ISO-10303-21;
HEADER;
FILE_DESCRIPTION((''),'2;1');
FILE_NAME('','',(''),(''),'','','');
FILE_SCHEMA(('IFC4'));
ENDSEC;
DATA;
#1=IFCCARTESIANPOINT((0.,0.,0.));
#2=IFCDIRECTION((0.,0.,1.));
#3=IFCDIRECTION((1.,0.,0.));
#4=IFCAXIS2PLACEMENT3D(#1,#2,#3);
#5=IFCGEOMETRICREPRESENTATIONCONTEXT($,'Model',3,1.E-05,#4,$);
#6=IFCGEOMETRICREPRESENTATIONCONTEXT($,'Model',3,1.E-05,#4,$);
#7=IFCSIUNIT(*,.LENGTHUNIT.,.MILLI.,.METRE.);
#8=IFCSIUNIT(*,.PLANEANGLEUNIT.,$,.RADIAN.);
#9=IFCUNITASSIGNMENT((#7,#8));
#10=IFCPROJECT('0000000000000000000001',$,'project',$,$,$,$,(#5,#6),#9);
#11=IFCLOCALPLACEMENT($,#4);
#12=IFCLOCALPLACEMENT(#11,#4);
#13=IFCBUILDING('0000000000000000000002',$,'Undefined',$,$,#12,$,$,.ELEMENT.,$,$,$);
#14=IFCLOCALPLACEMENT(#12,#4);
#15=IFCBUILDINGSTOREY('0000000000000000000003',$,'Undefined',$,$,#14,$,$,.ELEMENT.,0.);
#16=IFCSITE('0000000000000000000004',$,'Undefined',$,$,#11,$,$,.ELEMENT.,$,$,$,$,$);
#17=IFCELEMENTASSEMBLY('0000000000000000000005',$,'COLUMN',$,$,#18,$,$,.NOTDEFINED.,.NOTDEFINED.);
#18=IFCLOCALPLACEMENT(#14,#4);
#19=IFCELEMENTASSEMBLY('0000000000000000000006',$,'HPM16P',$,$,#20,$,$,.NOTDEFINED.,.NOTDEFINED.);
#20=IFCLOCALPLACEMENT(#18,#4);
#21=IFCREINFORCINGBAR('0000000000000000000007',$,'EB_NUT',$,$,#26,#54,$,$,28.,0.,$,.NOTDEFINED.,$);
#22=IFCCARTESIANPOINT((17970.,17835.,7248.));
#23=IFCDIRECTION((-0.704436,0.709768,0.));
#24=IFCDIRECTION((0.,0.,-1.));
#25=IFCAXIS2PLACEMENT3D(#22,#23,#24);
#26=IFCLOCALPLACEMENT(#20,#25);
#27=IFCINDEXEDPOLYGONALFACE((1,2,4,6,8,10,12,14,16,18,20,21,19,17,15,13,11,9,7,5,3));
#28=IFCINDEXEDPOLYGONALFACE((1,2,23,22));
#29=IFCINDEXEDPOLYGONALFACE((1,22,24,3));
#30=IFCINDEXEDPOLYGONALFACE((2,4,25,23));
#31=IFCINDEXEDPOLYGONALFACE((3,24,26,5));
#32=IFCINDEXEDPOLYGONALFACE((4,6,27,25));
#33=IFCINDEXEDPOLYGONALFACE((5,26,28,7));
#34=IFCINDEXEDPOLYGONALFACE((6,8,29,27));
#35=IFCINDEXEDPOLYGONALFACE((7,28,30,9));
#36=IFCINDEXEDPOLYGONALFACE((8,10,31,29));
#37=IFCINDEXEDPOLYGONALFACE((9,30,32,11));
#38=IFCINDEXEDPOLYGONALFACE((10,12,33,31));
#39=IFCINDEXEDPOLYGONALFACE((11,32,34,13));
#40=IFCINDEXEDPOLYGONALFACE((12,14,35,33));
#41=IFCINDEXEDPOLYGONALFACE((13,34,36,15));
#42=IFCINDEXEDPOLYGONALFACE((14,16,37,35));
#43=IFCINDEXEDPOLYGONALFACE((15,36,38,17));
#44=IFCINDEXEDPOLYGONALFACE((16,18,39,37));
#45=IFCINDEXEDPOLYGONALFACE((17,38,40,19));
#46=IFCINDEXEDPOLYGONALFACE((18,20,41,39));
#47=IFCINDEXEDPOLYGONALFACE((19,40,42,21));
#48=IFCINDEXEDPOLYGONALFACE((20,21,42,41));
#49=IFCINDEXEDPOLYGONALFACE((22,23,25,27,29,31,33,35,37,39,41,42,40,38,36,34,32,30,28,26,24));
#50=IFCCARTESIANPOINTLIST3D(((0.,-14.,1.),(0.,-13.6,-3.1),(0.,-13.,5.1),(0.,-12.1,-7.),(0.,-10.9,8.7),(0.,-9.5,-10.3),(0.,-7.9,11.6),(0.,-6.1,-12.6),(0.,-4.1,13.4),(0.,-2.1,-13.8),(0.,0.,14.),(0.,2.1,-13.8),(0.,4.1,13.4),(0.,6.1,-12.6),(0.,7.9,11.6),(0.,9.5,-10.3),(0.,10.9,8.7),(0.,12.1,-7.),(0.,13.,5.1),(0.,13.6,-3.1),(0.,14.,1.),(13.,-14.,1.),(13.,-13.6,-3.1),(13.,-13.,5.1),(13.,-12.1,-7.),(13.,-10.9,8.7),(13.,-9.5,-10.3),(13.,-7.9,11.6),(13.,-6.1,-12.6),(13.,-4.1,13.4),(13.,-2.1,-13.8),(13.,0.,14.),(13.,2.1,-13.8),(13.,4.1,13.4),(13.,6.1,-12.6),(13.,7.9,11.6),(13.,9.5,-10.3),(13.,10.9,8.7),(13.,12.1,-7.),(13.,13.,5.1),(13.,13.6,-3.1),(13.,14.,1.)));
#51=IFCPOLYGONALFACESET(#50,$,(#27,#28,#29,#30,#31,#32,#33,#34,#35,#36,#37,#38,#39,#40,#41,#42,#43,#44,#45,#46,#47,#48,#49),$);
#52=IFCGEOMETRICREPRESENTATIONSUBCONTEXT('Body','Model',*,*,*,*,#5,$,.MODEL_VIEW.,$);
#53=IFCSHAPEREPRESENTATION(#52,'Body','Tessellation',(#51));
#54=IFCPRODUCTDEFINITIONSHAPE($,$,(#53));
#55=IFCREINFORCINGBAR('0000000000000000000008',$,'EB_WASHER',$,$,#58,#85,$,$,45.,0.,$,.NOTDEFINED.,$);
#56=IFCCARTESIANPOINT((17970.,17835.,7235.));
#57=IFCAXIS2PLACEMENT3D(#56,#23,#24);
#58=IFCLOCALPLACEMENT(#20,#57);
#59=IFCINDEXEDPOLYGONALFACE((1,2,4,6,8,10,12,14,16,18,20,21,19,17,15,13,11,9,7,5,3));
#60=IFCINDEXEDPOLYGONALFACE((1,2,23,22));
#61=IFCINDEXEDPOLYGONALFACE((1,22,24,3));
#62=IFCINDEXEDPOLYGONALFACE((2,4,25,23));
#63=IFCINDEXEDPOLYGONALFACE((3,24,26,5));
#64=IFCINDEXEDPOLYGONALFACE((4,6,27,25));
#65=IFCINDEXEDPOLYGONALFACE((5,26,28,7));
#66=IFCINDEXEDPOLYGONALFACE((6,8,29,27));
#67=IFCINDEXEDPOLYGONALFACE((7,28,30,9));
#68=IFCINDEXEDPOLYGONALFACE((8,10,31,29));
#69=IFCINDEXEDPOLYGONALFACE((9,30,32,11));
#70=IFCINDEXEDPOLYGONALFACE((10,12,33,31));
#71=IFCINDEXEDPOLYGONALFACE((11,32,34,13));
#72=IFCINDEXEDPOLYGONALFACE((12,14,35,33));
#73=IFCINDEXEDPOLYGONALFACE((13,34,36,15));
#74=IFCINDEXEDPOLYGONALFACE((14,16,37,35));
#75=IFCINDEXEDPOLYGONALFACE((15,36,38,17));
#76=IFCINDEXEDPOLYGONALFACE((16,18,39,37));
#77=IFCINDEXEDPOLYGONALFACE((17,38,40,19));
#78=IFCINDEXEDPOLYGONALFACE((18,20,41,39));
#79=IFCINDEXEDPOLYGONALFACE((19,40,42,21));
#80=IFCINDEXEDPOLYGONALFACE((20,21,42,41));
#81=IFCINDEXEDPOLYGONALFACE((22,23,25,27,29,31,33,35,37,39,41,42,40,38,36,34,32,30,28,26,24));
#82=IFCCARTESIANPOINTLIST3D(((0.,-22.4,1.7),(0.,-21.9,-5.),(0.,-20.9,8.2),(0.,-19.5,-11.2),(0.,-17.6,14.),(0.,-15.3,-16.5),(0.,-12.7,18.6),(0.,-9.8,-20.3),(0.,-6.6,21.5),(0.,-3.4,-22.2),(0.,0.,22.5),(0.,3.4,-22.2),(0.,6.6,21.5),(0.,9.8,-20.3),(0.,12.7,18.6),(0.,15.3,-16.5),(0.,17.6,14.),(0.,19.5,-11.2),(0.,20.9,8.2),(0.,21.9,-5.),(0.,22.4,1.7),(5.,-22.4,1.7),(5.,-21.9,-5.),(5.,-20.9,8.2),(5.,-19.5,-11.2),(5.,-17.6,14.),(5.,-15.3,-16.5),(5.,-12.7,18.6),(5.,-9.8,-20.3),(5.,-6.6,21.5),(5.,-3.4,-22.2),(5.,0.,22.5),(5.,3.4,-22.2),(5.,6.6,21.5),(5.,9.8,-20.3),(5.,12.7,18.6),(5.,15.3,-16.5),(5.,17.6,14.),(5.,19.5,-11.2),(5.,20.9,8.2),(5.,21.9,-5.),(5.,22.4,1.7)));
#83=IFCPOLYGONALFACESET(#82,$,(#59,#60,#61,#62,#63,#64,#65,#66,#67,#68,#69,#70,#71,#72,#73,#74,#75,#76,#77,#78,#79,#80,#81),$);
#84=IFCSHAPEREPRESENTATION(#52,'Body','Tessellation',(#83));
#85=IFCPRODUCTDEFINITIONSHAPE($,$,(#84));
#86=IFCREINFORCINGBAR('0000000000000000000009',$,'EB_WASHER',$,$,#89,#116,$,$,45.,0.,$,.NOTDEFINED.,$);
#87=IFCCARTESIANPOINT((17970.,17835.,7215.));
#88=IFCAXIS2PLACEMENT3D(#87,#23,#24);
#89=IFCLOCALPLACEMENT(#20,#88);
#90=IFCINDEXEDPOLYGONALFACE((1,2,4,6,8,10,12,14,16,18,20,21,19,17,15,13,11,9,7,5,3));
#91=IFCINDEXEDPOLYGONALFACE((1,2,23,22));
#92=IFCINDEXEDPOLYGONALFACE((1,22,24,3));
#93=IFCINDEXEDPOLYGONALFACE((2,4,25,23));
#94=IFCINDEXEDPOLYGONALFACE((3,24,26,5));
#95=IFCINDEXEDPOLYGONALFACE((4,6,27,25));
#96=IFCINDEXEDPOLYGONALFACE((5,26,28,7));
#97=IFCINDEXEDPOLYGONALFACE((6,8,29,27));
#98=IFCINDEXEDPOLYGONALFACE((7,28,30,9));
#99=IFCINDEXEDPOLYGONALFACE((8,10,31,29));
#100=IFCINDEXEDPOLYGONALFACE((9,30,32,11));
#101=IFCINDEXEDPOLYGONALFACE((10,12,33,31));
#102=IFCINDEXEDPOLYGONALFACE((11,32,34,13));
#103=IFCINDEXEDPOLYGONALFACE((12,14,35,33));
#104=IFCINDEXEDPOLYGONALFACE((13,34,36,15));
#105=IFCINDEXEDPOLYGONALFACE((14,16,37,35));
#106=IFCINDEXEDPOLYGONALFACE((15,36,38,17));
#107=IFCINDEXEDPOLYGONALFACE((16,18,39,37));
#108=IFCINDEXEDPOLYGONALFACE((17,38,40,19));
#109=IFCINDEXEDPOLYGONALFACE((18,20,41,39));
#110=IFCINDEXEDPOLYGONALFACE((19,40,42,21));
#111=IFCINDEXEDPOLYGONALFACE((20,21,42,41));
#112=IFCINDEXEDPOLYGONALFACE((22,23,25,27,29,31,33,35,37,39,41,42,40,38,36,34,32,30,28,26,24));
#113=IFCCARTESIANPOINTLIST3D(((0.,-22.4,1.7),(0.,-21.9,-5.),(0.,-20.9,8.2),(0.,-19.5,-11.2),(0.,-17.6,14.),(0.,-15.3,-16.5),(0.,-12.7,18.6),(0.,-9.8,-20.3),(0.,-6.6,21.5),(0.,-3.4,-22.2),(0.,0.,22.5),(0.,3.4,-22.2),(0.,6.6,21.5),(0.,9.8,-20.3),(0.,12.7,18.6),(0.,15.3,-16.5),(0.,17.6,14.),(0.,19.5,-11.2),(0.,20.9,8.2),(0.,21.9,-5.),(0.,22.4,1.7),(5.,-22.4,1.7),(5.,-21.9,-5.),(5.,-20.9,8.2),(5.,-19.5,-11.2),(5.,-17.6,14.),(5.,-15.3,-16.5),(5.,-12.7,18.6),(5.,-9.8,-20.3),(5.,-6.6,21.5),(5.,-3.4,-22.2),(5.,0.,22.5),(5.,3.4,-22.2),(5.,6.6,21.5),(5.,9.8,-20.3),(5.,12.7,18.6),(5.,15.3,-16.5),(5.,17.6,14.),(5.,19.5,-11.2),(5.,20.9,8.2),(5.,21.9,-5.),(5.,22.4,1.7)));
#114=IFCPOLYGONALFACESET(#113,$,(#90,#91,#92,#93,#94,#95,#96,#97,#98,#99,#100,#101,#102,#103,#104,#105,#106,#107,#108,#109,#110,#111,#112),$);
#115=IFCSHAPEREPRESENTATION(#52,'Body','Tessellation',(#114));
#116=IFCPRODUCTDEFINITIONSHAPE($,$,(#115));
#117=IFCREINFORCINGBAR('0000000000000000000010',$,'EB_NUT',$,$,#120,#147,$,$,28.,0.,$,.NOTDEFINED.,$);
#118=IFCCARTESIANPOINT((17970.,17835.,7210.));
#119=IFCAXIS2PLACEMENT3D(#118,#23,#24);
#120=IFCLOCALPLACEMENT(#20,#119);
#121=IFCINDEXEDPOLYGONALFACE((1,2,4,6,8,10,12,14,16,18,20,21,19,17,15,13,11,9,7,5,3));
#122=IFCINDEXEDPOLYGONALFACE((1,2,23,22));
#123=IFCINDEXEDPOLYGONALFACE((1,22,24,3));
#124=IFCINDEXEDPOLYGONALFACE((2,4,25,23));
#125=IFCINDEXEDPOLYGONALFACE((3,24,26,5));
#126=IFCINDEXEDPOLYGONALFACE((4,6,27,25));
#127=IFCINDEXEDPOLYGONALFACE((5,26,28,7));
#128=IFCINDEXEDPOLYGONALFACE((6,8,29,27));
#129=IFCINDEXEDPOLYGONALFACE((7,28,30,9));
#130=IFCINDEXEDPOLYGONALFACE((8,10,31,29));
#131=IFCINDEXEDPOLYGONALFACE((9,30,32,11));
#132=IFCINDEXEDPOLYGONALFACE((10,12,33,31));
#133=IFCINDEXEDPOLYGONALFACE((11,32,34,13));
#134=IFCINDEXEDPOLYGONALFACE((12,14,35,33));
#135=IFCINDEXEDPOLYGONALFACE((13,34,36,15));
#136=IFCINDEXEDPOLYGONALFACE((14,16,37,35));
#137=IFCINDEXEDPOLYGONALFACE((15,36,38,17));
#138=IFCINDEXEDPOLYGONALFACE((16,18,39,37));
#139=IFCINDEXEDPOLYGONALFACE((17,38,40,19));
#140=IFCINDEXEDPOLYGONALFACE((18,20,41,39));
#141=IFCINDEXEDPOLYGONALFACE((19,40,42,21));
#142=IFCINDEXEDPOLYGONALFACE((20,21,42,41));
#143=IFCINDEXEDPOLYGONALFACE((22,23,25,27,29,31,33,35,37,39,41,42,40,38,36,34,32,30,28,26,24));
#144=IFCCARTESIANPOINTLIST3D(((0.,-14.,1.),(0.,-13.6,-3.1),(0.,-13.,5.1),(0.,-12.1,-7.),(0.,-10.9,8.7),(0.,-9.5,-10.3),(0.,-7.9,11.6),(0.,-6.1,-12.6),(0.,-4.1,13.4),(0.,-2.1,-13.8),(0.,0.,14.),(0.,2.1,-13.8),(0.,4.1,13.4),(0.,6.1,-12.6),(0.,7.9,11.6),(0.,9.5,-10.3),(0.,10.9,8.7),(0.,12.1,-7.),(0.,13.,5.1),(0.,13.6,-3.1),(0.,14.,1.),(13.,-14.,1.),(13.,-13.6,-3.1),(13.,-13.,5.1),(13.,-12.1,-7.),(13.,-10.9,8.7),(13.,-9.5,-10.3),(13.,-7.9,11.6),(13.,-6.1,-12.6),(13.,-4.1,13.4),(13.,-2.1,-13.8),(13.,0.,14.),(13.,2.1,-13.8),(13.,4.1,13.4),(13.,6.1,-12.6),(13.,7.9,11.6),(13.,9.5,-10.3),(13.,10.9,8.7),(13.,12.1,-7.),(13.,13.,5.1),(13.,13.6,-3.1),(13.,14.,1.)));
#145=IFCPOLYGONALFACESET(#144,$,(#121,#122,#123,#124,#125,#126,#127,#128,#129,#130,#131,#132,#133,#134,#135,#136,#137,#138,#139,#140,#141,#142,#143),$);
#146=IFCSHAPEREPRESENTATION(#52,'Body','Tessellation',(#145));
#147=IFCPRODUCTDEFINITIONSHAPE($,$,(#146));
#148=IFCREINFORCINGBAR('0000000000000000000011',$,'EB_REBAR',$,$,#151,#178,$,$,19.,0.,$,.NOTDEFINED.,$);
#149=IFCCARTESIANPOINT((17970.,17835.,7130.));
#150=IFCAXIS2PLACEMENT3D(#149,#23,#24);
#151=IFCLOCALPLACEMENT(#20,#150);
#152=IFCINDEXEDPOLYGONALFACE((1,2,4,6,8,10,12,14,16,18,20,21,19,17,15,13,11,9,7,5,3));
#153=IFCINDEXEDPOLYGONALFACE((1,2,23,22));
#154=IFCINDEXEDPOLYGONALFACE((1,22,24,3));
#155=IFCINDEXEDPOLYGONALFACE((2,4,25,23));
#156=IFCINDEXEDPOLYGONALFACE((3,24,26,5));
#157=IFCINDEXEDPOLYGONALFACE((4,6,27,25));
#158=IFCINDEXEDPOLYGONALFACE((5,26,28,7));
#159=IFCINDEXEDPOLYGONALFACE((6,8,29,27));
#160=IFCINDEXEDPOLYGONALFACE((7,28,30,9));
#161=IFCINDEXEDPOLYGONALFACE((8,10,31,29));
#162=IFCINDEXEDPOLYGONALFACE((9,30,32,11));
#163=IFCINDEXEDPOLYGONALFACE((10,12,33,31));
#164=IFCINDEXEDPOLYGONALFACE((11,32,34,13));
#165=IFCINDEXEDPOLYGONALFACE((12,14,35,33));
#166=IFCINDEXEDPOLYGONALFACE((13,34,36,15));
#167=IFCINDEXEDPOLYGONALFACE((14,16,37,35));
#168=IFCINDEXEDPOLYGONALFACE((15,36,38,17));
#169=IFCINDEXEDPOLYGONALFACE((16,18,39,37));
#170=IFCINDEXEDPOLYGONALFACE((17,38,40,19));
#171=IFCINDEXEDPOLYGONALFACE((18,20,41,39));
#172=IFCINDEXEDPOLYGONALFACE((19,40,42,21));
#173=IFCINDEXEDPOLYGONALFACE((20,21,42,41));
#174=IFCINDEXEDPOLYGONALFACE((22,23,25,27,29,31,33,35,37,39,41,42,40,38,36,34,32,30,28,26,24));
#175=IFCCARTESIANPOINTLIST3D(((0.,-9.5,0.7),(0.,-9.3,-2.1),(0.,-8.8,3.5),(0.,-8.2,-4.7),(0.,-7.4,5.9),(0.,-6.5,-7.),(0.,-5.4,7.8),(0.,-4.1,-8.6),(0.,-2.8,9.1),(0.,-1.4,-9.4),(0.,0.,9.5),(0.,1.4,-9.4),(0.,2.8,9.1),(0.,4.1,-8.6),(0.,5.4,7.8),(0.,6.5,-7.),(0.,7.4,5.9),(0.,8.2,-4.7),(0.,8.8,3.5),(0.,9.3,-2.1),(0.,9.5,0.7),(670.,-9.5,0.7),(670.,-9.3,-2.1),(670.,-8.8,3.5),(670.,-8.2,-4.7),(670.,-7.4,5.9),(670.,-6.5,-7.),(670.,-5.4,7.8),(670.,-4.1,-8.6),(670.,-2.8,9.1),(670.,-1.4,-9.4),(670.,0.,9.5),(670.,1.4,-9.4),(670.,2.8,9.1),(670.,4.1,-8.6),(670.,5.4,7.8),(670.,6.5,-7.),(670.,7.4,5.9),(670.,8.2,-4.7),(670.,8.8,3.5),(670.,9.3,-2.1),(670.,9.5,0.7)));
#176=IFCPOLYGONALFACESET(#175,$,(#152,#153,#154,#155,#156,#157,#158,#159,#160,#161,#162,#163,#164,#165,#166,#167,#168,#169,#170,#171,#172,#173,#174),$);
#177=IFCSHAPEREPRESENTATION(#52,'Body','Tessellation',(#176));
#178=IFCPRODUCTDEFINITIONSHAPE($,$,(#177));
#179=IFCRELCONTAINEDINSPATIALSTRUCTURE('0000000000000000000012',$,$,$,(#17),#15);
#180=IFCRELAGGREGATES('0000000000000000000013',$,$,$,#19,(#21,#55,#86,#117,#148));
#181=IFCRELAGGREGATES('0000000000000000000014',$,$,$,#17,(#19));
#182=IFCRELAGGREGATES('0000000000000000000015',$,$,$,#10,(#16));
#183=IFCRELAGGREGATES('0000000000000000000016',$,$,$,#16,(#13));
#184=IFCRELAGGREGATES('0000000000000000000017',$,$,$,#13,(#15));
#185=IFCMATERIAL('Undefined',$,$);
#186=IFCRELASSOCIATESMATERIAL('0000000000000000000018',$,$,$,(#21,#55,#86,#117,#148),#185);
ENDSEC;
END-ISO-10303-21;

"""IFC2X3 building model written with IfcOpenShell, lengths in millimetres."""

from ifc_helpers import new_model, entity, si_unit, frame, origin_with_axes, place, context, subcontext, project, spatial, source, transform, mapped, material, element, aggregate, save


model = new_model("IFC2X3")

# Units and contexts
model_context_1 = context("Model", 3, precision=1e-05, world=origin_with_axes())
model_context_2 = context("Model", 3, precision=1e-05, world=origin_with_axes())
body_context = subcontext(model_context_1, "Body", "Model", "MODEL_VIEW")
ifc_project = project(units=[si_unit("LENGTHUNIT", "METRE", prefix="MILLI"), si_unit("PLANEANGLEUNIT", "RADIAN")], contexts=[model_context_1, model_context_2])

# Site, building, storey
site_placement = place(None, origin_with_axes())
site = spatial("IfcSite", under=ifc_project, at=site_placement, Name="Undefined", CompositionType="ELEMENT")
building_placement = place(site_placement, origin_with_axes())
building = spatial("IfcBuilding", under=site, at=building_placement, Name="Undefined", CompositionType="ELEMENT")
storey_placement = place(building_placement, origin_with_axes())
storey = spatial("IfcBuildingStorey", under=building, at=storey_placement, Name="Undefined", CompositionType="ELEMENT", Elevation=0.0)

# Element assemblies
assembly_1_placement = place(storey_placement, origin_with_axes())
assembly_1 = element("IfcElementAssembly", 1, at=assembly_1_placement, inside=storey, Name="COLUMN", AssemblyPlace="NOTDEFINED", PredefinedType="NOTDEFINED")
assembly_2_placement = place(assembly_1_placement, origin_with_axes())
assembly_2 = element("IfcElementAssembly", 2, at=assembly_2_placement, Name="HPM16P", AssemblyPlace="NOTDEFINED", PredefinedType="NOTDEFINED")

# Shared definitions
ifc_material_1 = material(Name="Undefined")

# Reinforcing bars
shared_shape_1 = source(origin_with_axes(), body_context, "Body", "AdvancedSweptSolid", [
    entity("IfcSweptDiskSolid", entity("IfcTrimmedCurve", entity("IfcLine", entity("IfcCartesianPoint", [0.0, 0.0, 0.0]), entity("IfcVector", entity("IfcDirection", [1.0, 0.0, 0.0]), 1.0)), [entity("IfcParameterValue", 0.0)], [entity("IfcParameterValue", 13.0)], True, "PARAMETER"), 14.0, None, 0.0, 13.0),
])
reinforcing_bar_1_placement = place(assembly_2_placement, frame((17970.0, 17835.0, 7248.0), z_axis=(-0.704436, 0.709768, 0.0), x_axis=(0.0, 0.0, -1.0)))
reinforcing_bar_1 = element("IfcReinforcingBar", 3, at=reinforcing_bar_1_placement, material=ifc_material_1, Name="EB_NUT", BarRole="NOTDEFINED", CrossSectionArea=0.0, NominalDiameter=28.0, context=body_context, shape_type="MappedRepresentation", body=[
    mapped(shared_shape_1, transform((0.0, 0.0, 0.0))),
])
shared_shape_2 = source(origin_with_axes(), body_context, "Body", "AdvancedSweptSolid", [
    entity("IfcSweptDiskSolid", entity("IfcTrimmedCurve", entity("IfcLine", entity("IfcCartesianPoint", [0.0, 0.0, 0.0]), entity("IfcVector", entity("IfcDirection", [1.0, 0.0, 0.0]), 1.0)), [entity("IfcParameterValue", 0.0)], [entity("IfcParameterValue", 5.0)], True, "PARAMETER"), 22.5, None, 0.0, 5.0),
])
reinforcing_bar_2_placement = place(assembly_2_placement, frame((17970.0, 17835.0, 7235.0), z_axis=(-0.704436, 0.709768, 0.0), x_axis=(0.0, 0.0, -1.0)))
reinforcing_bar_2 = element("IfcReinforcingBar", 4, at=reinforcing_bar_2_placement, material=ifc_material_1, Name="EB_WASHER", BarRole="NOTDEFINED", CrossSectionArea=0.0, NominalDiameter=45.0, context=body_context, shape_type="MappedRepresentation", body=[
    mapped(shared_shape_2, transform((0.0, 0.0, 0.0))),
])
shared_shape_3 = source(origin_with_axes(), body_context, "Body", "AdvancedSweptSolid", [
    entity("IfcSweptDiskSolid", entity("IfcTrimmedCurve", entity("IfcLine", entity("IfcCartesianPoint", [0.0, 0.0, 0.0]), entity("IfcVector", entity("IfcDirection", [1.0, 0.0, 0.0]), 1.0)), [entity("IfcParameterValue", 0.0)], [entity("IfcParameterValue", 5.0)], True, "PARAMETER"), 22.5, None, 0.0, 5.0),
])
reinforcing_bar_3_placement = place(assembly_2_placement, frame((17970.0, 17835.0, 7215.0), z_axis=(-0.704436, 0.709768, 0.0), x_axis=(0.0, 0.0, -1.0)))
reinforcing_bar_3 = element("IfcReinforcingBar", 5, at=reinforcing_bar_3_placement, material=ifc_material_1, Name="EB_WASHER", BarRole="NOTDEFINED", CrossSectionArea=0.0, NominalDiameter=45.0, context=body_context, shape_type="MappedRepresentation", body=[
    mapped(shared_shape_3, transform((0.0, 0.0, 0.0))),
])
shared_shape_4 = source(origin_with_axes(), body_context, "Body", "AdvancedSweptSolid", [
    entity("IfcSweptDiskSolid", entity("IfcTrimmedCurve", entity("IfcLine", entity("IfcCartesianPoint", [0.0, 0.0, 0.0]), entity("IfcVector", entity("IfcDirection", [1.0, 0.0, 0.0]), 1.0)), [entity("IfcParameterValue", 0.0)], [entity("IfcParameterValue", 13.0)], True, "PARAMETER"), 14.0, None, 0.0, 13.0),
])
reinforcing_bar_4_placement = place(assembly_2_placement, frame((17970.0, 17835.0, 7210.0), z_axis=(-0.704436, 0.709768, 0.0), x_axis=(0.0, 0.0, -1.0)))
reinforcing_bar_4 = element("IfcReinforcingBar", 6, at=reinforcing_bar_4_placement, material=ifc_material_1, Name="EB_NUT", BarRole="NOTDEFINED", CrossSectionArea=0.0, NominalDiameter=28.0, context=body_context, shape_type="MappedRepresentation", body=[
    mapped(shared_shape_4, transform((0.0, 0.0, 0.0))),
])
shared_shape_5 = source(origin_with_axes(), body_context, "Body", "AdvancedSweptSolid", [
    entity("IfcSweptDiskSolid", entity("IfcTrimmedCurve", entity("IfcLine", entity("IfcCartesianPoint", [0.0, 0.0, 0.0]), entity("IfcVector", entity("IfcDirection", [1.0, 0.0, 0.0]), 1.0)), [entity("IfcParameterValue", 0.0)], [entity("IfcParameterValue", 670.0)], True, "PARAMETER"), 9.5, None, 0.0, 670.0),
])
reinforcing_bar_5_placement = place(assembly_2_placement, frame((17970.0, 17835.0, 7130.0), z_axis=(-0.704436, 0.709768, 0.0), x_axis=(0.0, 0.0, -1.0)))
reinforcing_bar_5 = element("IfcReinforcingBar", 7, at=reinforcing_bar_5_placement, material=ifc_material_1, Name="EB_REBAR", BarRole="NOTDEFINED", CrossSectionArea=0.0, NominalDiameter=19.0, context=body_context, shape_type="MappedRepresentation", body=[
    mapped(shared_shape_5, transform((0.0, 0.0, 0.0))),
])
aggregate(assembly_2, [reinforcing_bar_1, reinforcing_bar_2, reinforcing_bar_3, reinforcing_bar_4, reinforcing_bar_5])

aggregate(assembly_1, [assembly_2])

save(model, "model.ifc")
